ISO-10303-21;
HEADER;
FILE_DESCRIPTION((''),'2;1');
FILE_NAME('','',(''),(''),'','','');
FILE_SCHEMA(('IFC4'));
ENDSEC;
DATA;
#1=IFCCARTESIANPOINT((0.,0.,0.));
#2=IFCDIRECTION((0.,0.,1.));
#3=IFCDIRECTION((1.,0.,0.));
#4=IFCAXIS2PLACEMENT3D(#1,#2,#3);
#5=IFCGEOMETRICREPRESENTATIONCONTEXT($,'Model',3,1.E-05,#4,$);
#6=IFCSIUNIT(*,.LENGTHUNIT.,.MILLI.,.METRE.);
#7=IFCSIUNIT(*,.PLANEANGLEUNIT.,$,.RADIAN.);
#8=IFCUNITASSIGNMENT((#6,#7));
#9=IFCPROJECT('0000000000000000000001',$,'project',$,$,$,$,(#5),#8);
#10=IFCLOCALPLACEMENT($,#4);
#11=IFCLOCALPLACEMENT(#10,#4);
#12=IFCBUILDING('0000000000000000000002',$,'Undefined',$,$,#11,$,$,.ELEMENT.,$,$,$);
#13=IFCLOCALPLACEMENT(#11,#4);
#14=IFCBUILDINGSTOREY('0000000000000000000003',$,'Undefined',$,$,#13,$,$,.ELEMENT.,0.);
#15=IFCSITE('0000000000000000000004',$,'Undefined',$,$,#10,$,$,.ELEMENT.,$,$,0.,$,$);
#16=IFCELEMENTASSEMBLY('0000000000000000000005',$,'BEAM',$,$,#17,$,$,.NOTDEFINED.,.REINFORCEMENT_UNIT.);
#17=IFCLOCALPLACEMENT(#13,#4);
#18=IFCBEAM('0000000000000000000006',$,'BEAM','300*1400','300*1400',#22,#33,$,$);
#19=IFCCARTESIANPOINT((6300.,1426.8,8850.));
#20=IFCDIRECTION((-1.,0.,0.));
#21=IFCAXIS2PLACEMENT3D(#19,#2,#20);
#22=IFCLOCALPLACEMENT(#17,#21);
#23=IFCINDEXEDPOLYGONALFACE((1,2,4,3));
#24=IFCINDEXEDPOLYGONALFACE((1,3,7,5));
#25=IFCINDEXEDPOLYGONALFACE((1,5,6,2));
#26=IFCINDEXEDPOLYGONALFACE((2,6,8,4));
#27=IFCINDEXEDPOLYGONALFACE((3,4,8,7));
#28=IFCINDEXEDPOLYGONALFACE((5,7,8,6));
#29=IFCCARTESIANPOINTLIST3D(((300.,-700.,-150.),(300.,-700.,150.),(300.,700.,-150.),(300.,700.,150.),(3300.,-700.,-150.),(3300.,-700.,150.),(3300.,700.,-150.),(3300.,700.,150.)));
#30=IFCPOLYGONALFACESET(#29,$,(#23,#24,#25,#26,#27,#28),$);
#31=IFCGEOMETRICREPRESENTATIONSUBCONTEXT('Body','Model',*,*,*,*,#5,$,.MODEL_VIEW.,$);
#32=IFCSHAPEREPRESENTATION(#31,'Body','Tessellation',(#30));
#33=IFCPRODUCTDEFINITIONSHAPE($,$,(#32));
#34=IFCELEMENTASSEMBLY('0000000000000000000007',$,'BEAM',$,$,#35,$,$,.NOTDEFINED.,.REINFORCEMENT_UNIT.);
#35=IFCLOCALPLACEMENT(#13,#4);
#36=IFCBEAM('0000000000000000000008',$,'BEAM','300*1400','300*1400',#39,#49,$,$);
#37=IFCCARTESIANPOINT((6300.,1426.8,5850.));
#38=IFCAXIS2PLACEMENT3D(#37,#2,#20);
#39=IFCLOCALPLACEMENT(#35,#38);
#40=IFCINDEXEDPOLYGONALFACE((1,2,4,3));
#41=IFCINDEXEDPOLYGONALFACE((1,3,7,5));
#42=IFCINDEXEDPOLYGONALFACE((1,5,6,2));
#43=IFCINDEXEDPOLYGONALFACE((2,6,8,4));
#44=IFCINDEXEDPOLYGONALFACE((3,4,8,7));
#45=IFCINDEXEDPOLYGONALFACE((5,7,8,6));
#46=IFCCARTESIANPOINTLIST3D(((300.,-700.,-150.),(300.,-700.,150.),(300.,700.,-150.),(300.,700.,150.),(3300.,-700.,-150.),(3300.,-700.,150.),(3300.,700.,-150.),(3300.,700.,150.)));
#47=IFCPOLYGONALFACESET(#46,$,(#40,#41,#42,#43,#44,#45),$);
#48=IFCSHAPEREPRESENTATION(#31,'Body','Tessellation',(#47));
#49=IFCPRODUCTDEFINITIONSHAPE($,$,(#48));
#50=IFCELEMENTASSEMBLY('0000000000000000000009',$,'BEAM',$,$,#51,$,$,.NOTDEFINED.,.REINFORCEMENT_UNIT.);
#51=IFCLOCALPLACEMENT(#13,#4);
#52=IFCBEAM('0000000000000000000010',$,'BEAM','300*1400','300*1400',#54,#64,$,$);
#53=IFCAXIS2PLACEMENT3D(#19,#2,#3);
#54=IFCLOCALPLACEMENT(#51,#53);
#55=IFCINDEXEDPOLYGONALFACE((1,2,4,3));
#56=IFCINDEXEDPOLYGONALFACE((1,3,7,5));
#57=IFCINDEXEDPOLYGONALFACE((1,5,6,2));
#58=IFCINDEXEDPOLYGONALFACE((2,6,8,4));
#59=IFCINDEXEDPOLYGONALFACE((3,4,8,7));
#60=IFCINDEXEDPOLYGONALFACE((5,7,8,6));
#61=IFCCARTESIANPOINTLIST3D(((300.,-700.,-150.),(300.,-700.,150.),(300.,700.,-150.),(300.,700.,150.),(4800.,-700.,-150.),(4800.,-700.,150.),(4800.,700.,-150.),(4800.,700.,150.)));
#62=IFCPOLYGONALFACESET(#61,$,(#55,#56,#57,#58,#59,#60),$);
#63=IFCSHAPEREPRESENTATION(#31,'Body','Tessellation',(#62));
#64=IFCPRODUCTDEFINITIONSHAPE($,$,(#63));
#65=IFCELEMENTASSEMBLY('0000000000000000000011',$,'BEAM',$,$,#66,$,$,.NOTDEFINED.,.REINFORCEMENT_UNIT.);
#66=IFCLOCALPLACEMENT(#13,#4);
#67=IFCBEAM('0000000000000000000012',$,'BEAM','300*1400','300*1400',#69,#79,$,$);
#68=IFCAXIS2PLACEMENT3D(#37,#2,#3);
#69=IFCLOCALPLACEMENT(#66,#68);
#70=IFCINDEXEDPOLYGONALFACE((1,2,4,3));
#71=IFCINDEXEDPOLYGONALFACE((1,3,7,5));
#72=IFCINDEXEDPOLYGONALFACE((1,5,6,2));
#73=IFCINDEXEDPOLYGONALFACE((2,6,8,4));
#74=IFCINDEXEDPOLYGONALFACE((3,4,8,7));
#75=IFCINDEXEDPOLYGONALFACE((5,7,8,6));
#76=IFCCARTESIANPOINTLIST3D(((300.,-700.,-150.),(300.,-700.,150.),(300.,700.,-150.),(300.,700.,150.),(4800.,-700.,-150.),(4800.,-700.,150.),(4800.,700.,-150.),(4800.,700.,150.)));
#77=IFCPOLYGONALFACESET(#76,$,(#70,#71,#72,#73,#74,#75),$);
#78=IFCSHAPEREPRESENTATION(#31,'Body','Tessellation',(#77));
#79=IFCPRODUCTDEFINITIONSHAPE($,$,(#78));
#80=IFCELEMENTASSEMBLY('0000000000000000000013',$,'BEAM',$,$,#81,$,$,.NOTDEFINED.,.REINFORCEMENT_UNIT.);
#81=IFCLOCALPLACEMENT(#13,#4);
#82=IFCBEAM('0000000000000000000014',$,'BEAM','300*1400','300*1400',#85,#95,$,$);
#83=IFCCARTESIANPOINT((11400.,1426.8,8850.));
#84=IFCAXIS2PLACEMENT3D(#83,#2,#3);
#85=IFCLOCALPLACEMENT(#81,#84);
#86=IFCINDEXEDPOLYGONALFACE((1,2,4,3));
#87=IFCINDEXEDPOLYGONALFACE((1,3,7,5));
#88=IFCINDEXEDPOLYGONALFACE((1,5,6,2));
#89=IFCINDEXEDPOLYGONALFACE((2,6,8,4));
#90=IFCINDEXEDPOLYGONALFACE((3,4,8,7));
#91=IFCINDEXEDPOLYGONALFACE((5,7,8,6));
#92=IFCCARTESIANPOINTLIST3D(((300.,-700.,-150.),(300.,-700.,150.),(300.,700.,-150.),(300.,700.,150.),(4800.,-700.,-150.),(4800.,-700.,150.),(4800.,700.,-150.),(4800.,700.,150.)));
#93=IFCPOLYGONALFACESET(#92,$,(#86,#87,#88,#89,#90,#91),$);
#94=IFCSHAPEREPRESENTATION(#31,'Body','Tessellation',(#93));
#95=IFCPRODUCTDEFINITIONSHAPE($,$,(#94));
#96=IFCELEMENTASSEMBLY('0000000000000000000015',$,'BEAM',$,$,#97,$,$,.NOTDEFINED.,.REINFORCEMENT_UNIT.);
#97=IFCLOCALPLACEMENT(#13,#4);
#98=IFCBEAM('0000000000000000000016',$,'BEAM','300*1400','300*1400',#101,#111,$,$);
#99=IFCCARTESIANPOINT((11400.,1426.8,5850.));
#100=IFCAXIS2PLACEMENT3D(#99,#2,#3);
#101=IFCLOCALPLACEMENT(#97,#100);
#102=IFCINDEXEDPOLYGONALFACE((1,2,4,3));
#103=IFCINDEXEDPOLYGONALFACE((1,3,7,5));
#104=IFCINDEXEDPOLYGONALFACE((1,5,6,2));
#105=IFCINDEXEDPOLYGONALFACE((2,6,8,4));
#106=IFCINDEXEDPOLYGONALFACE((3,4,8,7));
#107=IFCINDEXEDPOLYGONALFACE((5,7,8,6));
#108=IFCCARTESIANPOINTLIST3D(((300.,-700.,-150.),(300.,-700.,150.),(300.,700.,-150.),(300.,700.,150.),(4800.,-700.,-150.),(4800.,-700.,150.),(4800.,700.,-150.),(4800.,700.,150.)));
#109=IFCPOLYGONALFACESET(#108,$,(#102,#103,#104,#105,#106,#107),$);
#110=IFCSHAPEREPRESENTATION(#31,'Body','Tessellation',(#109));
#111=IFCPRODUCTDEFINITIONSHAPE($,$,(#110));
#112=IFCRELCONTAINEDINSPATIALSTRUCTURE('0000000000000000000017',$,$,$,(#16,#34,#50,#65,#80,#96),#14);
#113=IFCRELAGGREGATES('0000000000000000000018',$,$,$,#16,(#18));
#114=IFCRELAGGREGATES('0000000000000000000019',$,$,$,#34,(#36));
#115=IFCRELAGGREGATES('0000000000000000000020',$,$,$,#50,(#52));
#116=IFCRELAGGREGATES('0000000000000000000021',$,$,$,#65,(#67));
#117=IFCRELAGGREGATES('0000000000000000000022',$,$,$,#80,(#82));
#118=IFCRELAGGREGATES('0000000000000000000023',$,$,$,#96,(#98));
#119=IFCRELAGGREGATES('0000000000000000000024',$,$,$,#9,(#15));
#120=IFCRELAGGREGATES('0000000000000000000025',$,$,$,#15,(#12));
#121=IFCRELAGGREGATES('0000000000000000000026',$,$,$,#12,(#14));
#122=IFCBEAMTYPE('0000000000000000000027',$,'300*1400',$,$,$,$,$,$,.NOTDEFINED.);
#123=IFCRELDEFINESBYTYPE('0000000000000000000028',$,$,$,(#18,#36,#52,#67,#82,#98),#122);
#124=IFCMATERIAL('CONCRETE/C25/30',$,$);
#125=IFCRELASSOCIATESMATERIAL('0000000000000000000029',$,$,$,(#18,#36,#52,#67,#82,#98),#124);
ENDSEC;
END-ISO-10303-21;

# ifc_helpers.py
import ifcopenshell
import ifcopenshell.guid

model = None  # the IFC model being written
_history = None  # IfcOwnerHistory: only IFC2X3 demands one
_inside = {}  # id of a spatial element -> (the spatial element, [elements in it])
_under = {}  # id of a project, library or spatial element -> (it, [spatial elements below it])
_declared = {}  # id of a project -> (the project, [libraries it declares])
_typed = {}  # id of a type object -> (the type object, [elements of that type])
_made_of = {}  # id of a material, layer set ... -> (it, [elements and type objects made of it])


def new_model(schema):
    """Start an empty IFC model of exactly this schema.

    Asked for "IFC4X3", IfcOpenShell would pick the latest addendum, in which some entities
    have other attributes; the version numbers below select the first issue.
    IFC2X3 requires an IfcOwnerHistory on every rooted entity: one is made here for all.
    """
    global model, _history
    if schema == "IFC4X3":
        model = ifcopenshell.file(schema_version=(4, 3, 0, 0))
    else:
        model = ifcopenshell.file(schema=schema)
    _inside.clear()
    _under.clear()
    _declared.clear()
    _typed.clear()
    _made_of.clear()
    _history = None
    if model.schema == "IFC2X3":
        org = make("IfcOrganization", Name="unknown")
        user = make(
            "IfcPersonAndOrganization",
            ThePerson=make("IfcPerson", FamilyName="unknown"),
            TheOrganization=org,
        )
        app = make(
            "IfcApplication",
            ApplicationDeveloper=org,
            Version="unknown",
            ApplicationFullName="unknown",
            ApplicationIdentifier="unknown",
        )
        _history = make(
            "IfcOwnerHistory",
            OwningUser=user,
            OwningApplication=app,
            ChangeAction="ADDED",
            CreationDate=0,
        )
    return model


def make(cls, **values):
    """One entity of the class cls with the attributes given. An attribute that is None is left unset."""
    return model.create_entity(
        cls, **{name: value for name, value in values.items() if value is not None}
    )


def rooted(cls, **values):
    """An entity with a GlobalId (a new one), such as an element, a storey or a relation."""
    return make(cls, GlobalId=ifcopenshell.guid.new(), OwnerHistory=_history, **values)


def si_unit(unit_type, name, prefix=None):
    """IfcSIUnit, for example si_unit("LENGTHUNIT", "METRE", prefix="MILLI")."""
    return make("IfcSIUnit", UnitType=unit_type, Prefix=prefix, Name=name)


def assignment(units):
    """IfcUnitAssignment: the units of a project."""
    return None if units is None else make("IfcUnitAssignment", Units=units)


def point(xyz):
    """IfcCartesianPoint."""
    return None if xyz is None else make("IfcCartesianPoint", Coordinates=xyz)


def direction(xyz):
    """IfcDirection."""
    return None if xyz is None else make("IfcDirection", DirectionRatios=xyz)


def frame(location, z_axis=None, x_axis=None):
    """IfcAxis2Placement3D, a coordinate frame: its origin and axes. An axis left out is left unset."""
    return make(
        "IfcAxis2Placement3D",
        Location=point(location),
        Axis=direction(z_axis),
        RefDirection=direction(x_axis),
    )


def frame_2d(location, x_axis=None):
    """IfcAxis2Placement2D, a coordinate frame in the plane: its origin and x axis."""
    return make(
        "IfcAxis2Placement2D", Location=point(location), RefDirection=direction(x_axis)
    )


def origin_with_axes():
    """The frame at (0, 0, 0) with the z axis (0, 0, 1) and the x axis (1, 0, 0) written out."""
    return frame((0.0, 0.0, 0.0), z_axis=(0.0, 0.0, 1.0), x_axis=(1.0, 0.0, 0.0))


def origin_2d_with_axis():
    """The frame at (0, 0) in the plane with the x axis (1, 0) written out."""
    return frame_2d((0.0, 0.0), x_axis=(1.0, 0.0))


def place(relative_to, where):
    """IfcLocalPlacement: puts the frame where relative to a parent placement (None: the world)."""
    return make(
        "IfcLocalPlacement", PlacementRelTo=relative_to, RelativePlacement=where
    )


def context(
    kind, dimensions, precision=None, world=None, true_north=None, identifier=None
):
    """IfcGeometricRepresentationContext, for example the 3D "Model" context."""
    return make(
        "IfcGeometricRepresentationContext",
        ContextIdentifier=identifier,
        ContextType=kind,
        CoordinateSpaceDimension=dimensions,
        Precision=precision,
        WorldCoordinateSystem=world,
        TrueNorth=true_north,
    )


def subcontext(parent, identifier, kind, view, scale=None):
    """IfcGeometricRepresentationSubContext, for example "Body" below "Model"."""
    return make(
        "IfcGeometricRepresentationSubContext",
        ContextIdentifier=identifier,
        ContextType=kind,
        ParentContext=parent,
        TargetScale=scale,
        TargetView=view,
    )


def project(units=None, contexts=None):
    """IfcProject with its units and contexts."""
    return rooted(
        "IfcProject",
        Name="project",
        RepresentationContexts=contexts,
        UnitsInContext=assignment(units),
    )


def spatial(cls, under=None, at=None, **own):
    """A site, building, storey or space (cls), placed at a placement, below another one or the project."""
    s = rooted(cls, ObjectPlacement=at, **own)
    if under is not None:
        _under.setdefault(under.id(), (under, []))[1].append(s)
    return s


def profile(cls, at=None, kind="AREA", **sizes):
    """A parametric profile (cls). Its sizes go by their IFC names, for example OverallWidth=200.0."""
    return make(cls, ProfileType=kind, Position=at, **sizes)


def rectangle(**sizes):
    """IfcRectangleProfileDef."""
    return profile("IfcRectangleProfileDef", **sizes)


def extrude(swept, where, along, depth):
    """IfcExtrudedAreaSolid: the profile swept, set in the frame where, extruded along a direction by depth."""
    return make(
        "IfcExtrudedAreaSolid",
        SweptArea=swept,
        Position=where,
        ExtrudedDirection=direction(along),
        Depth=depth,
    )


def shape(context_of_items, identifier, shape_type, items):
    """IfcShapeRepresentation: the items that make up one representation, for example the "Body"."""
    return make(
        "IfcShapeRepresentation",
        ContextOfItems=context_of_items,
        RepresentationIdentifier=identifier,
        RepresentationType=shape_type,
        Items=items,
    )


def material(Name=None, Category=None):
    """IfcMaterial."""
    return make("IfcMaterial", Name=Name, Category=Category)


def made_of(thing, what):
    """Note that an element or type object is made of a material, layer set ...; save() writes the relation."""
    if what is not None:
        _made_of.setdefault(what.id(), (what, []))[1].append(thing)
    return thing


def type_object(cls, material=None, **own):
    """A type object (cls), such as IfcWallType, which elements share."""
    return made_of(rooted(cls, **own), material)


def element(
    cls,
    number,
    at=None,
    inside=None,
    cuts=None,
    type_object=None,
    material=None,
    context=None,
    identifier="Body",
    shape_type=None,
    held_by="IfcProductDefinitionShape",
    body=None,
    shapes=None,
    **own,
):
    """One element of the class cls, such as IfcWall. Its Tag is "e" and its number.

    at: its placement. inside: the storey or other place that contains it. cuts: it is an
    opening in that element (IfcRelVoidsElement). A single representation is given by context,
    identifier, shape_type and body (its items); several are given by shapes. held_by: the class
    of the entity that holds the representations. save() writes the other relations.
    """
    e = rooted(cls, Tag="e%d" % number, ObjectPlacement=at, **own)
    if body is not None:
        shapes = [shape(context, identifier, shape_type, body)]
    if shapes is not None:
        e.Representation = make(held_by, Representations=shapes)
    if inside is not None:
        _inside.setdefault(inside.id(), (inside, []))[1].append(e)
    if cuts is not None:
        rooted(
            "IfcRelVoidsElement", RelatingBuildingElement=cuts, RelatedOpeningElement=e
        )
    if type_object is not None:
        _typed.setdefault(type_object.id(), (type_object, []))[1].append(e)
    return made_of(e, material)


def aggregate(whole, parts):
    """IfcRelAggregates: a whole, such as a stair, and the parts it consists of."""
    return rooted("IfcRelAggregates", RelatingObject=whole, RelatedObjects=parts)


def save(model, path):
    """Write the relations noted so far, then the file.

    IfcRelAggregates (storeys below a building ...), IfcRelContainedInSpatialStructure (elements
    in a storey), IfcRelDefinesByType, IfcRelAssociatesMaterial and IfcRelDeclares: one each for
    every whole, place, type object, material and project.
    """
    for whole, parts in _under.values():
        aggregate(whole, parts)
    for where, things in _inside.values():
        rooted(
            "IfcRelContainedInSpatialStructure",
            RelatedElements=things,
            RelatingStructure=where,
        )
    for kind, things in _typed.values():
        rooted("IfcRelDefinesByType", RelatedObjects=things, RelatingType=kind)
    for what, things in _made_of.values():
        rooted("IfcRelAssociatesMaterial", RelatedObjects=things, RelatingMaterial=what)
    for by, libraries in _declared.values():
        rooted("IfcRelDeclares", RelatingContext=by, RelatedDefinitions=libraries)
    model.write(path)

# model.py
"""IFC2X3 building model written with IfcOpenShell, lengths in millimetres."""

from ifc_helpers import new_model, si_unit, frame, origin_with_axes, origin_2d_with_axis, place, context, subcontext, project, spatial, rectangle, extrude, material, type_object, element, aggregate, save


model = new_model("IFC2X3")

# Units and contexts
model_context = context("Model", 3, precision=1e-05, world=origin_with_axes())
body_context = subcontext(model_context, "Body", "Model", "MODEL_VIEW")
ifc_project = project(units=[si_unit("LENGTHUNIT", "METRE", prefix="MILLI"), si_unit("PLANEANGLEUNIT", "RADIAN")], contexts=[model_context])

# Site, building, storey
site_placement = place(None, origin_with_axes())
site = spatial("IfcSite", under=ifc_project, at=site_placement, Name="Undefined", CompositionType="ELEMENT", RefElevation=0.0)
building_placement = place(site_placement, origin_with_axes())
building = spatial("IfcBuilding", under=site, at=building_placement, Name="Undefined", CompositionType="ELEMENT")
storey_placement = place(building_placement, origin_with_axes())
storey = spatial("IfcBuildingStorey", under=building, at=storey_placement, Name="Undefined", CompositionType="ELEMENT", Elevation=0.0)

# Shared definitions
ifc_material = material(Name="CONCRETE/C25/30")

# Element assemblies, beams
assembly_1_placement = place(storey_placement, origin_with_axes())
assembly_1 = element("IfcElementAssembly", 1, at=assembly_1_placement, inside=storey, Name="BEAM", AssemblyPlace="NOTDEFINED", PredefinedType="REINFORCEMENT_UNIT")
beam_type_1 = type_object("IfcBeamType", Name="300*1400", PredefinedType="NOTDEFINED")
beam_1_placement = place(assembly_1_placement, frame((6300.0, 1426.8, 8850.0), z_axis=(0.0, 0.0, 1.0), x_axis=(-1.0, 0.0, 0.0)))
beam_1 = element("IfcBeam", 2, at=beam_1_placement, type_object=beam_type_1, material=ifc_material, Name="BEAM", Description="300*1400", ObjectType="300*1400", context=body_context, shape_type="SweptSolid", body=[
    extrude(rectangle(XDim=1400.0, YDim=300.0, at=origin_2d_with_axis()), frame((3300.0, 0.0, 0.0), z_axis=(-1.0, 0.0, 0.0), x_axis=(0.0, -1.0, 0.0)), (0.0, 0.0, 1.0), 3000.0),
])
aggregate(assembly_1, [beam_1])
assembly_2_placement = place(storey_placement, origin_with_axes())
assembly_2 = element("IfcElementAssembly", 3, at=assembly_2_placement, inside=storey, Name="BEAM", AssemblyPlace="NOTDEFINED", PredefinedType="REINFORCEMENT_UNIT")
beam_2_placement = place(assembly_2_placement, frame((6300.0, 1426.8, 5850.0), z_axis=(0.0, 0.0, 1.0), x_axis=(-1.0, 0.0, 0.0)))
beam_2 = element("IfcBeam", 4, at=beam_2_placement, type_object=beam_type_1, material=ifc_material, Name="BEAM", Description="300*1400", ObjectType="300*1400", context=body_context, shape_type="SweptSolid", body=[
    extrude(rectangle(XDim=1400.0, YDim=300.0, at=origin_2d_with_axis()), frame((3300.0, 0.0, 0.0), z_axis=(-1.0, 0.0, 0.0), x_axis=(0.0, -1.0, 0.0)), (0.0, 0.0, 1.0), 3000.0),
])
aggregate(assembly_2, [beam_2])
assembly_3_placement = place(storey_placement, origin_with_axes())
assembly_3 = element("IfcElementAssembly", 5, at=assembly_3_placement, inside=storey, Name="BEAM", AssemblyPlace="NOTDEFINED", PredefinedType="REINFORCEMENT_UNIT")
beam_3_placement = place(assembly_3_placement, frame((6300.0, 1426.8, 8850.0), z_axis=(0.0, 0.0, 1.0), x_axis=(1.0, 0.0, 0.0)))
beam_3 = element("IfcBeam", 6, at=beam_3_placement, type_object=beam_type_1, material=ifc_material, Name="BEAM", Description="300*1400", ObjectType="300*1400", context=body_context, shape_type="SweptSolid", body=[
    extrude(rectangle(XDim=1400.0, YDim=300.0, at=origin_2d_with_axis()), frame((4800.0, 0.0, 0.0), z_axis=(-1.0, 0.0, 0.0), x_axis=(0.0, -1.0, 0.0)), (0.0, 0.0, 1.0), 4500.0),
])
aggregate(assembly_3, [beam_3])
assembly_4_placement = place(storey_placement, origin_with_axes())
assembly_4 = element("IfcElementAssembly", 7, at=assembly_4_placement, inside=storey, Name="BEAM", AssemblyPlace="NOTDEFINED", PredefinedType="REINFORCEMENT_UNIT")
beam_4_placement = place(assembly_4_placement, frame((6300.0, 1426.8, 5850.0), z_axis=(0.0, 0.0, 1.0), x_axis=(1.0, 0.0, 0.0)))
beam_4 = element("IfcBeam", 8, at=beam_4_placement, type_object=beam_type_1, material=ifc_material, Name="BEAM", Description="300*1400", ObjectType="300*1400", context=body_context, shape_type="SweptSolid", body=[
    extrude(rectangle(XDim=1400.0, YDim=300.0, at=origin_2d_with_axis()), frame((4800.0, 0.0, 0.0), z_axis=(-1.0, 0.0, 0.0), x_axis=(0.0, -1.0, 0.0)), (0.0, 0.0, 1.0), 4500.0),
])
aggregate(assembly_4, [beam_4])
assembly_5_placement = place(storey_placement, origin_with_axes())
assembly_5 = element("IfcElementAssembly", 9, at=assembly_5_placement, inside=storey, Name="BEAM", AssemblyPlace="NOTDEFINED", PredefinedType="REINFORCEMENT_UNIT")
beam_5_placement = place(assembly_5_placement, frame((11400.0, 1426.8, 8850.0), z_axis=(0.0, 0.0, 1.0), x_axis=(1.0, 0.0, 0.0)))
beam_5 = element("IfcBeam", 10, at=beam_5_placement, type_object=beam_type_1, material=ifc_material, Name="BEAM", Description="300*1400", ObjectType="300*1400", context=body_context, shape_type="SweptSolid", body=[
    extrude(rectangle(XDim=1400.0, YDim=300.0, at=origin_2d_with_axis()), frame((4800.0, 0.0, 0.0), z_axis=(-1.0, 0.0, 0.0), x_axis=(0.0, -1.0, 0.0)), (0.0, 0.0, 1.0), 4500.0),
])
aggregate(assembly_5, [beam_5])
assembly_6_placement = place(storey_placement, origin_with_axes())
assembly_6 = element("IfcElementAssembly", 11, at=assembly_6_placement, inside=storey, Name="BEAM", AssemblyPlace="NOTDEFINED", PredefinedType="REINFORCEMENT_UNIT")
beam_6_placement = place(assembly_6_placement, frame((11400.0, 1426.8, 5850.0), z_axis=(0.0, 0.0, 1.0), x_axis=(1.0, 0.0, 0.0)))
beam_6 = element("IfcBeam", 12, at=beam_6_placement, type_object=beam_type_1, material=ifc_material, Name="BEAM", Description="300*1400", ObjectType="300*1400", context=body_context, shape_type="SweptSolid", body=[
    extrude(rectangle(XDim=1400.0, YDim=300.0, at=origin_2d_with_axis()), frame((4800.0, 0.0, 0.0), z_axis=(-1.0, 0.0, 0.0), x_axis=(0.0, -1.0, 0.0)), (0.0, 0.0, 1.0), 4500.0),
])
aggregate(assembly_6, [beam_6])

save(model, "model.ifc")
